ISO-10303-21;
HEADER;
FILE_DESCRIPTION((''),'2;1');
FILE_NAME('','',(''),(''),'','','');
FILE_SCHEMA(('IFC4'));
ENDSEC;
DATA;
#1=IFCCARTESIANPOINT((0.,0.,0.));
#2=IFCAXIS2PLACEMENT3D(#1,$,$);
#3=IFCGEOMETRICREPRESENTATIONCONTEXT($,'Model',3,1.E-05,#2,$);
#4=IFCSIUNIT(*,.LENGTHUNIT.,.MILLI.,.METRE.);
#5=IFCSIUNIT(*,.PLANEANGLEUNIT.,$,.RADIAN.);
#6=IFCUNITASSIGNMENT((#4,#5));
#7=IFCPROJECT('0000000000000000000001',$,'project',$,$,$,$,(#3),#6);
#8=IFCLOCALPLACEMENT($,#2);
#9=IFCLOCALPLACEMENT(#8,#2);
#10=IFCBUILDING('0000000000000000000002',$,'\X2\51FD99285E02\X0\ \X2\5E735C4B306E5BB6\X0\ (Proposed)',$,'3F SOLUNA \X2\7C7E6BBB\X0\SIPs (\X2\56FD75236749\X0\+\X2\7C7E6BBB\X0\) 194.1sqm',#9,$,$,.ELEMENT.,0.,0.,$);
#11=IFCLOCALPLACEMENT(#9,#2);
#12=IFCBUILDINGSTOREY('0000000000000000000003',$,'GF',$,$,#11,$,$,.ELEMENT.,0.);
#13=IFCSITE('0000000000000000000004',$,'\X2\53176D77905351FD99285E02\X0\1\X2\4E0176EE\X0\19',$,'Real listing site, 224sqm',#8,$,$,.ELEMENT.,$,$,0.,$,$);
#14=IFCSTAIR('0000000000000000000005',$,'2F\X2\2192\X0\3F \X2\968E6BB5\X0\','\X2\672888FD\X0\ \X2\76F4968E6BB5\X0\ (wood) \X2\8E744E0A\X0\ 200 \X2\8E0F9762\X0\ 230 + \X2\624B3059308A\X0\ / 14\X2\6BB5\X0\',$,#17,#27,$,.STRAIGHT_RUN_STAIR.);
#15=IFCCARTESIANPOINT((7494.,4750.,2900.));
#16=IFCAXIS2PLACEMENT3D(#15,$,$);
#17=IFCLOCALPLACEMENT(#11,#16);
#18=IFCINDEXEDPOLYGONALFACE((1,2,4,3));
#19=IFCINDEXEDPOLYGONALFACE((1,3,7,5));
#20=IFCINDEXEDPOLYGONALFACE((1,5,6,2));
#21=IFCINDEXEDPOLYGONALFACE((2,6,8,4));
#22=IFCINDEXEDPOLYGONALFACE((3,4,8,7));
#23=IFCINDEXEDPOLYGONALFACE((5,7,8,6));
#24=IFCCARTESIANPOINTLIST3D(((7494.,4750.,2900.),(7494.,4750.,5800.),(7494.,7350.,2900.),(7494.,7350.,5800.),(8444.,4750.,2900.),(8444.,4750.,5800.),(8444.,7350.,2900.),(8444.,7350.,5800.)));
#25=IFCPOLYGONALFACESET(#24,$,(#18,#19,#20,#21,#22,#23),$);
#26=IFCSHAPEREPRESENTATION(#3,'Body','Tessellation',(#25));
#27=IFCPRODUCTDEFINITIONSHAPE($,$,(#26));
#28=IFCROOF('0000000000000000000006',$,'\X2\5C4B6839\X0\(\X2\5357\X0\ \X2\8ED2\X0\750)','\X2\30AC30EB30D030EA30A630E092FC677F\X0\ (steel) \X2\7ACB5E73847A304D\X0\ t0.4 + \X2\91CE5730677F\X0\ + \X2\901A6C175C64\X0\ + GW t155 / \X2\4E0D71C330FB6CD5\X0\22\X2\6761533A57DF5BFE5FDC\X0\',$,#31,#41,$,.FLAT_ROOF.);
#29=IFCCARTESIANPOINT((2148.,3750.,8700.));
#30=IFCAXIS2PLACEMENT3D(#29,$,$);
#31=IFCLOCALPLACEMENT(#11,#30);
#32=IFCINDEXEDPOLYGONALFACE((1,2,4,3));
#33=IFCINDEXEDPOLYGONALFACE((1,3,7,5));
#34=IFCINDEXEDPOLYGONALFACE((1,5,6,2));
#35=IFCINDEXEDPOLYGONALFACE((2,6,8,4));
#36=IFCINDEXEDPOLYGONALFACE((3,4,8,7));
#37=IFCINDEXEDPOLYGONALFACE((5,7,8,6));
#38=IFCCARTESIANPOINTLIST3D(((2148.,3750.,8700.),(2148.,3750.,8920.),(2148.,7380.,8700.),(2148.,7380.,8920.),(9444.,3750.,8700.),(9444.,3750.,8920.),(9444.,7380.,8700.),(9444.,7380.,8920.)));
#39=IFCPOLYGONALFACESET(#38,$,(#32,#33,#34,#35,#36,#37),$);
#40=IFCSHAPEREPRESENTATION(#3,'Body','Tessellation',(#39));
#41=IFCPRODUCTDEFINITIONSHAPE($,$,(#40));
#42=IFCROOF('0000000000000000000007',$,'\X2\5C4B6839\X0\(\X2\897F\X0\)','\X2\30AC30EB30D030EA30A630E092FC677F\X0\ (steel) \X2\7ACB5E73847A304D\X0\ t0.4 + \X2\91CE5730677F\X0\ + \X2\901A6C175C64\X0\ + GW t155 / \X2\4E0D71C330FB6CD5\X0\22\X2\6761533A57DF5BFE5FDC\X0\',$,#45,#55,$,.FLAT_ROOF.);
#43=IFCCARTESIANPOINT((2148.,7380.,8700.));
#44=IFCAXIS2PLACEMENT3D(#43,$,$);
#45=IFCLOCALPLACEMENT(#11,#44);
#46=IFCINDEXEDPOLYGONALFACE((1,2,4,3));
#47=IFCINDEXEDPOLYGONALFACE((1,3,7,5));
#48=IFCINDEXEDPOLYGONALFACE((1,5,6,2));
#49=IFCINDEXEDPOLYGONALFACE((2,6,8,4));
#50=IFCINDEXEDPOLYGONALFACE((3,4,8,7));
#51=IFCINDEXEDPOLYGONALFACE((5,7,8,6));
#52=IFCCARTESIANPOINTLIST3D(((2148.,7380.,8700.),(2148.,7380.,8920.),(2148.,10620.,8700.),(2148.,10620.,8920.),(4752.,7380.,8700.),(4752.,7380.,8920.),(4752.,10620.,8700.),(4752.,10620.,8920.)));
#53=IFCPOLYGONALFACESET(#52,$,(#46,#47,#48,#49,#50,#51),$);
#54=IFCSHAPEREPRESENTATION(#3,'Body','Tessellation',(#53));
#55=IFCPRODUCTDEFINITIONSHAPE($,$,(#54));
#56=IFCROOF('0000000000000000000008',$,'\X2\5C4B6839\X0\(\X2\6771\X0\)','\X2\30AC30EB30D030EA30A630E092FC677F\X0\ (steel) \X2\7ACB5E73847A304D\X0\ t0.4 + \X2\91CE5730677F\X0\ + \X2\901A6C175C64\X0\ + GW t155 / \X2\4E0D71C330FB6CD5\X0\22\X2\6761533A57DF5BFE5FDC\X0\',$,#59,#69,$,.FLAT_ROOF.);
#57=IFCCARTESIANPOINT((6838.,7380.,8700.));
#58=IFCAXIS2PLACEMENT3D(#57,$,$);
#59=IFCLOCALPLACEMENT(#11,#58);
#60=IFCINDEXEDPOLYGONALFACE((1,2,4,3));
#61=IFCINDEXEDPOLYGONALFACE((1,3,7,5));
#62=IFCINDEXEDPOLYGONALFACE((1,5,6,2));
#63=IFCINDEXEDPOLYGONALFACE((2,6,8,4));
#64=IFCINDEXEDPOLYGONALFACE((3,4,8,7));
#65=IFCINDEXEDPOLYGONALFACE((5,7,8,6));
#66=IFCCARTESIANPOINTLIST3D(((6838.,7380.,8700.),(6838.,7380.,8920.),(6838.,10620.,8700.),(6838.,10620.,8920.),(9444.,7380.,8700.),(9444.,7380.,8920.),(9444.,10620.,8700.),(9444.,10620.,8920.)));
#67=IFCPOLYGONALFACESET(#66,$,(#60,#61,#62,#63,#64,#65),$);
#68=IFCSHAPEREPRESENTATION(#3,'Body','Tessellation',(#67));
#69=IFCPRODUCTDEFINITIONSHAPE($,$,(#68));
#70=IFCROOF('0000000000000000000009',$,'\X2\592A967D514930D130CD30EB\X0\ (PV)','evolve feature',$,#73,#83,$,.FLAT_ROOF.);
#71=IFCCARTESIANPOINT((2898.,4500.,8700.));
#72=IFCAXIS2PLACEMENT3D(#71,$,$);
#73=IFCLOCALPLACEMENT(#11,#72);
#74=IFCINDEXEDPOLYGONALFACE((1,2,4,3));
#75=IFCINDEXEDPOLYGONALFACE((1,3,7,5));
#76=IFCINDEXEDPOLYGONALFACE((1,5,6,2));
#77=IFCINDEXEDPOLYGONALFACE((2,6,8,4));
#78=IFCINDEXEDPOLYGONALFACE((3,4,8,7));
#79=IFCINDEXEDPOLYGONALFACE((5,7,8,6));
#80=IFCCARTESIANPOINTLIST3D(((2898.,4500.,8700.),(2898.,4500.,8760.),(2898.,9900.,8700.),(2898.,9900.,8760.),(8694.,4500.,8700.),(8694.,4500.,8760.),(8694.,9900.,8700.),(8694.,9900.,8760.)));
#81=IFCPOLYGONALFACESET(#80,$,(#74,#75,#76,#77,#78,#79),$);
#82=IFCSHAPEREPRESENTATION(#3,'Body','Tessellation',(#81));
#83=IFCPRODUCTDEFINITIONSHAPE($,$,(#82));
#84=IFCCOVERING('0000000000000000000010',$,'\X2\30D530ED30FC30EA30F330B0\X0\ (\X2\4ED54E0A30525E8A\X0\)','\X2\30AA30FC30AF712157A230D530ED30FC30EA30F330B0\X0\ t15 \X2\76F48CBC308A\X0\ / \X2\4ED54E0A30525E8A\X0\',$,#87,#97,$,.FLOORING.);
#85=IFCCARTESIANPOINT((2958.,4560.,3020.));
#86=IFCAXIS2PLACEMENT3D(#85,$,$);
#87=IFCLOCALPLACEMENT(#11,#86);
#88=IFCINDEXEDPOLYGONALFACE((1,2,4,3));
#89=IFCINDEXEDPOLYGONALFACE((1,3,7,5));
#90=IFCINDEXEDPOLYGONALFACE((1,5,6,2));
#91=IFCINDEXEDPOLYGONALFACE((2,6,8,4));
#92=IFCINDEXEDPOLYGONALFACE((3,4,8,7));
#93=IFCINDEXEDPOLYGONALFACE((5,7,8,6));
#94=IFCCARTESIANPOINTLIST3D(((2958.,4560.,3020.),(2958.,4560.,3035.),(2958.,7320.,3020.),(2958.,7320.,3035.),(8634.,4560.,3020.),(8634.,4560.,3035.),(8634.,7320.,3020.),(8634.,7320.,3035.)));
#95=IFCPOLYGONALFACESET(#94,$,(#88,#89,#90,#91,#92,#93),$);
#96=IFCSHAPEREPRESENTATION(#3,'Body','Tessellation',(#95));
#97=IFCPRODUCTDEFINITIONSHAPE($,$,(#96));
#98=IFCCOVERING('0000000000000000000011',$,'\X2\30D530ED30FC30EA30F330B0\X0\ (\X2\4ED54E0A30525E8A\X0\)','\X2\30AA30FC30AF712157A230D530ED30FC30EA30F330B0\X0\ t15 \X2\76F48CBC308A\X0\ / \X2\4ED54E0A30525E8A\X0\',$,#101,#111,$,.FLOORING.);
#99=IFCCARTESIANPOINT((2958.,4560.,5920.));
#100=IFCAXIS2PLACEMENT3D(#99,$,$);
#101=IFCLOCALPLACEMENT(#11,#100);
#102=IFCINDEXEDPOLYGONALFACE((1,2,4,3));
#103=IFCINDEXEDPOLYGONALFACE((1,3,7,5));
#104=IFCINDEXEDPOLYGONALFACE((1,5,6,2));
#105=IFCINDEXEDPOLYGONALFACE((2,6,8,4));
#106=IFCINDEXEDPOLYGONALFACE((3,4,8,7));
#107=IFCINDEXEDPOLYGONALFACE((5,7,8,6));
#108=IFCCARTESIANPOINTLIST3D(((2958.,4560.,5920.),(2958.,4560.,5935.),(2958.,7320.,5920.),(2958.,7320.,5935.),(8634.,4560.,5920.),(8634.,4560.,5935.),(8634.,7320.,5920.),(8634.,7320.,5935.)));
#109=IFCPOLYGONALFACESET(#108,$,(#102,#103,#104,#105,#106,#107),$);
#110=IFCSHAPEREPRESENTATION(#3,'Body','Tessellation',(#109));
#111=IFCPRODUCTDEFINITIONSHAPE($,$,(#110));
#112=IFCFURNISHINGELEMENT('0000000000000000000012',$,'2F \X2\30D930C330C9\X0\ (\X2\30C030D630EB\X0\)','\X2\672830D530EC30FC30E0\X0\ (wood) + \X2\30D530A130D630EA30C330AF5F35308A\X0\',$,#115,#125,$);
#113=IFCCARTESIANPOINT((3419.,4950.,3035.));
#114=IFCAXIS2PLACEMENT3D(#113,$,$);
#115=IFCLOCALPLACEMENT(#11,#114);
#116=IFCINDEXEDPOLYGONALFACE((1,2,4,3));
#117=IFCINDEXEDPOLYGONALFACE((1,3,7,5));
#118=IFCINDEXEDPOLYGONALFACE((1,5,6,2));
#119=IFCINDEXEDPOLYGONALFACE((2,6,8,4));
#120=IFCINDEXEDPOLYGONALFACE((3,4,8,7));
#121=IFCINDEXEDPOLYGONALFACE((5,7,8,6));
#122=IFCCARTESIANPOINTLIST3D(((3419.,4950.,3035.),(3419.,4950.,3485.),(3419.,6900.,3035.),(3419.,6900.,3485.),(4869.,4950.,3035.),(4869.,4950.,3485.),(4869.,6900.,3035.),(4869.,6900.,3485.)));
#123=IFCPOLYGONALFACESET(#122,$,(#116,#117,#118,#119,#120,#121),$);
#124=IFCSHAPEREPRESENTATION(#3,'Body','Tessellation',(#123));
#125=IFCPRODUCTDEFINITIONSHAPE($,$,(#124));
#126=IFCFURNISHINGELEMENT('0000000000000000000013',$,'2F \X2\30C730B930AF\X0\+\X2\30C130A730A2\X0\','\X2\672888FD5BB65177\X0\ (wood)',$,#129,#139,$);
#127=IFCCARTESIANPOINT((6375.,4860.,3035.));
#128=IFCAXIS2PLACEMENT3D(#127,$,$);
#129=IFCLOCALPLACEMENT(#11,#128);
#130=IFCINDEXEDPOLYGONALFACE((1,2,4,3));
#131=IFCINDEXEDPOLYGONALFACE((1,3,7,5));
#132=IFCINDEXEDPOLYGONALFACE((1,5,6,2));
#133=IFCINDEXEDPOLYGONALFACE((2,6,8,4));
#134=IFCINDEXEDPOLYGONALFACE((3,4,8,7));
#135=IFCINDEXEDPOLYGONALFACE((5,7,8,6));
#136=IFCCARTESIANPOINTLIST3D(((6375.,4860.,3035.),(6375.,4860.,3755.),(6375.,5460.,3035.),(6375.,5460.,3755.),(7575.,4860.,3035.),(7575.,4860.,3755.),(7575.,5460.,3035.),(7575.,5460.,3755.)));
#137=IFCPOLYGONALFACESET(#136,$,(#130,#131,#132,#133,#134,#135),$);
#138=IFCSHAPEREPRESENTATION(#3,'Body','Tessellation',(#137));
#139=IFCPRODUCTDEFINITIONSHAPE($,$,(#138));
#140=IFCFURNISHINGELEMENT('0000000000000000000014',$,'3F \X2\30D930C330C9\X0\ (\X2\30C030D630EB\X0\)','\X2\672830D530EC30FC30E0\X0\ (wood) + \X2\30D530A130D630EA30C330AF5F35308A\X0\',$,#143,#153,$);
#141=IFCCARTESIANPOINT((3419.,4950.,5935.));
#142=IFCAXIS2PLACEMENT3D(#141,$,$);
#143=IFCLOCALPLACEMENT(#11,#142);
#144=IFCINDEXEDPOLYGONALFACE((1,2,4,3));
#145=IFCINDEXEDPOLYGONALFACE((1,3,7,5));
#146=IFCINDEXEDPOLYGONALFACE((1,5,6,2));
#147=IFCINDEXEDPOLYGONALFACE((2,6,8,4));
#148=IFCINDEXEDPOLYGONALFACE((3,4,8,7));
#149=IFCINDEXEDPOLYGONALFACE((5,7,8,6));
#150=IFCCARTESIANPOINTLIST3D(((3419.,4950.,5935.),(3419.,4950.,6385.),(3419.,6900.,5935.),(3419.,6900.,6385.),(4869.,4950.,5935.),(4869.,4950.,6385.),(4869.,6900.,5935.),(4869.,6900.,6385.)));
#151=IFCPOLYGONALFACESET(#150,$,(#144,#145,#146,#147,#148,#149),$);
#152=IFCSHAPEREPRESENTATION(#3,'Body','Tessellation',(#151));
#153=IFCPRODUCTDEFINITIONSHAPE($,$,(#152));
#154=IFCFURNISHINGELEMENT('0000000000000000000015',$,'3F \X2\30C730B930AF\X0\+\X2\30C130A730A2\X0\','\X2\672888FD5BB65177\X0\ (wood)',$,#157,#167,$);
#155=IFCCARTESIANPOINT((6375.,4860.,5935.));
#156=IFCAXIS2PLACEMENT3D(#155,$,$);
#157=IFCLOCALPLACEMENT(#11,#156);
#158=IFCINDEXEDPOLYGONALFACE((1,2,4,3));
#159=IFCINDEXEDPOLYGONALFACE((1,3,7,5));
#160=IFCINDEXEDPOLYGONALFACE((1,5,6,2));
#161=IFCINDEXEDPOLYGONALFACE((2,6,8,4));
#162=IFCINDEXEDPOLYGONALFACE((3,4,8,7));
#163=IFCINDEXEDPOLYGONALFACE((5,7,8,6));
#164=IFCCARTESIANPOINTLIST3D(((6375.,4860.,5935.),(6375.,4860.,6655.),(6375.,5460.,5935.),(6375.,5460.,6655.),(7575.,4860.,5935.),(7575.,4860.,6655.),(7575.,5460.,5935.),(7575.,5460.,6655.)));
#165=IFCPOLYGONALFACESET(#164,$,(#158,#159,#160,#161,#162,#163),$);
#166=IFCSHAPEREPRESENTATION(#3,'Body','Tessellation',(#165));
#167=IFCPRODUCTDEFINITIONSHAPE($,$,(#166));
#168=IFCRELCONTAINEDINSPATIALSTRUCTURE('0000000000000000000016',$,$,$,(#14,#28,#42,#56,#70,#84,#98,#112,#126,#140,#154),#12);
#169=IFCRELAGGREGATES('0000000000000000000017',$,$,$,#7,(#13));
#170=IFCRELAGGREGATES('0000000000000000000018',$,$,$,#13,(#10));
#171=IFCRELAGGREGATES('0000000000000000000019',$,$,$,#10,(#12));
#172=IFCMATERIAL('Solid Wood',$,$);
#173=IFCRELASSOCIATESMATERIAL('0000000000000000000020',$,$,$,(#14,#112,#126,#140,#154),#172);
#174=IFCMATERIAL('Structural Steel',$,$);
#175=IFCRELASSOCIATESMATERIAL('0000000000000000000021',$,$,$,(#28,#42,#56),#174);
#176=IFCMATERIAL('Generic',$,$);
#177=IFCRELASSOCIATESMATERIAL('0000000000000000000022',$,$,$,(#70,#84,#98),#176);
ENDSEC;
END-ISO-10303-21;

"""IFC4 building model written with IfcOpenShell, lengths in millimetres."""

from ifc_helpers import new_model, si_unit, frame, frame_2d, origin, place, context, project, spatial, rectangle, extrude, material, element, save


model = new_model("IFC4")

# Units and contexts
model_context = context("Model", 3, precision=1e-05, world=origin())
ifc_project = project(units=[si_unit("LENGTHUNIT", "METRE", prefix="MILLI"), si_unit("PLANEANGLEUNIT", "RADIAN")], contexts=[model_context])

# Site, building, storey
site_placement = place(None, origin())
site = spatial("IfcSite", under=ifc_project, at=site_placement, Name="北海道函館市1丁目19", ObjectType="Real listing site, 224sqm", CompositionType="ELEMENT", RefElevation=0.0)
building_placement = place(site_placement, origin())
building = spatial("IfcBuilding", under=site, at=building_placement, Name="函館市 平屋の家 (Proposed)", ObjectType="3F SOLUNA 籾殻SIPs (国産杉+籾殻) 194.1sqm", CompositionType="ELEMENT", ElevationOfRefHeight=0.0, ElevationOfTerrain=0.0)
storey_placement = place(building_placement, origin())
storey = spatial("IfcBuildingStorey", under=building, at=storey_placement, Name="GF", CompositionType="ELEMENT", Elevation=0.0)

# Shared definitions
ifc_material_1 = material(Name="Solid Wood")

# Stair
stair_placement = place(storey_placement, frame((7494.0, 4750.0, 2900.0)))
element("IfcStair", 1, at=stair_placement, inside=storey, material=ifc_material_1, Name="2F→3F 階段", Description="木製 直階段 (wood) 蹴上 200 踏面 230 + 手すり / 14段", PredefinedType="STRAIGHT_RUN_STAIR", context=model_context, shape_type="SweptSolid", body=[
    extrude(rectangle(XDim=950.0, YDim=2600.0, at=frame_2d((475.0, 1300.0))), frame((7494.0, 4750.0, 2900.0)), (0.0, 0.0, 1.0), 2900.0),
])

# Roofs
ifc_material_2 = material(Name="Structural Steel")
roof_1_placement = place(storey_placement, frame((2148.0, 3750.0, 8700.0)))
element("IfcRoof", 2, at=roof_1_placement, inside=storey, material=ifc_material_2, Name="屋根(南 軒750)", Description="ガルバリウム鋼板 (steel) 立平葺き t0.4 + 野地板 + 通気層 + GW t155 / 不燃・法22条区域対応", PredefinedType="FLAT_ROOF", context=model_context, shape_type="SweptSolid", body=[
    extrude(rectangle(XDim=7296.0, YDim=3630.0, at=frame_2d((3648.0, 1815.0))), frame((2148.0, 3750.0, 8700.0)), (0.0, 0.0, 1.0), 220.0),
])
roof_2_placement = place(storey_placement, frame((2148.0, 7380.0, 8700.0)))
element("IfcRoof", 3, at=roof_2_placement, inside=storey, material=ifc_material_2, Name="屋根(西)", Description="ガルバリウム鋼板 (steel) 立平葺き t0.4 + 野地板 + 通気層 + GW t155 / 不燃・法22条区域対応", PredefinedType="FLAT_ROOF", context=model_context, shape_type="SweptSolid", body=[
    extrude(rectangle(XDim=2604.0, YDim=3240.0, at=frame_2d((1302.0, 1620.0))), frame((2148.0, 7380.0, 8700.0)), (0.0, 0.0, 1.0), 220.0),
])
roof_3_placement = place(storey_placement, frame((6838.0, 7380.0, 8700.0)))
element("IfcRoof", 4, at=roof_3_placement, inside=storey, material=ifc_material_2, Name="屋根(東)", Description="ガルバリウム鋼板 (steel) 立平葺き t0.4 + 野地板 + 通気層 + GW t155 / 不燃・法22条区域対応", PredefinedType="FLAT_ROOF", context=model_context, shape_type="SweptSolid", body=[
    extrude(rectangle(XDim=2606.0, YDim=3240.0, at=frame_2d((1303.0, 1620.0))), frame((6838.0, 7380.0, 8700.0)), (0.0, 0.0, 1.0), 220.0),
])
ifc_material_3 = material(Name="Generic")
roof_4_placement = place(storey_placement, frame((2898.0, 4500.0, 8700.0)))
element("IfcRoof", 5, at=roof_4_placement, inside=storey, material=ifc_material_3, Name="太陽光パネル (PV)", Description="evolve feature", PredefinedType="FLAT_ROOF", context=model_context, shape_type="SweptSolid", body=[
    extrude(rectangle(XDim=5796.0, YDim=5400.0, at=frame_2d((2898.0, 2700.0))), frame((2898.0, 4500.0, 8700.0)), (0.0, 0.0, 1.0), 60.0),
])

# Coverings
covering_1_placement = place(storey_placement, frame((2958.0, 4560.0, 3020.0)))
element("IfcCovering", 6, at=covering_1_placement, inside=storey, material=ifc_material_3, Name="フローリング (仕上げ床)", Description="オーク無垢フローリング t15 直貼り / 仕上げ床", PredefinedType="FLOORING", context=model_context, shape_type="SweptSolid", body=[
    extrude(rectangle(XDim=5676.0, YDim=2760.0, at=frame_2d((2838.0, 1380.0))), frame((2958.0, 4560.0, 3020.0)), (0.0, 0.0, 1.0), 15.0),
])
covering_2_placement = place(storey_placement, frame((2958.0, 4560.0, 5920.0)))
element("IfcCovering", 7, at=covering_2_placement, inside=storey, material=ifc_material_3, Name="フローリング (仕上げ床)", Description="オーク無垢フローリング t15 直貼り / 仕上げ床", PredefinedType="FLOORING", context=model_context, shape_type="SweptSolid", body=[
    extrude(rectangle(XDim=5676.0, YDim=2760.0, at=frame_2d((2838.0, 1380.0))), frame((2958.0, 4560.0, 5920.0)), (0.0, 0.0, 1.0), 15.0),
])

# Furnishing elements
furnishing_1_placement = place(storey_placement, frame((3419.0, 4950.0, 3035.0)))
element("IfcFurnishingElement", 8, at=furnishing_1_placement, inside=storey, material=ifc_material_1, Name="2F ベッド (ダブル)", Description="木フレーム (wood) + ファブリック張り", context=model_context, shape_type="SweptSolid", body=[
    extrude(rectangle(XDim=1450.0, YDim=1950.0, at=frame_2d((725.0, 975.0))), frame((3419.0, 4950.0, 3035.0)), (0.0, 0.0, 1.0), 450.0),
])
furnishing_2_placement = place(storey_placement, frame((6375.0, 4860.0, 3035.0)))
element("IfcFurnishingElement", 9, at=furnishing_2_placement, inside=storey, material=ifc_material_1, Name="2F デスク+チェア", Description="木製家具 (wood)", context=model_context, shape_type="SweptSolid", body=[
    extrude(rectangle(XDim=1200.0, YDim=600.0, at=frame_2d((600.0, 300.0))), frame((6375.0, 4860.0, 3035.0)), (0.0, 0.0, 1.0), 720.0),
])
furnishing_3_placement = place(storey_placement, frame((3419.0, 4950.0, 5935.0)))
element("IfcFurnishingElement", 10, at=furnishing_3_placement, inside=storey, material=ifc_material_1, Name="3F ベッド (ダブル)", Description="木フレーム (wood) + ファブリック張り", context=model_context, shape_type="SweptSolid", body=[
    extrude(rectangle(XDim=1450.0, YDim=1950.0, at=frame_2d((725.0, 975.0))), frame((3419.0, 4950.0, 5935.0)), (0.0, 0.0, 1.0), 450.0),
])
furnishing_4_placement = place(storey_placement, frame((6375.0, 4860.0, 5935.0)))
element("IfcFurnishingElement", 11, at=furnishing_4_placement, inside=storey, material=ifc_material_1, Name="3F デスク+チェア", Description="木製家具 (wood)", context=model_context, shape_type="SweptSolid", body=[
    extrude(rectangle(XDim=1200.0, YDim=600.0, at=frame_2d((600.0, 300.0))), frame((6375.0, 4860.0, 5935.0)), (0.0, 0.0, 1.0), 720.0),
])

save(model, "model.ifc")
